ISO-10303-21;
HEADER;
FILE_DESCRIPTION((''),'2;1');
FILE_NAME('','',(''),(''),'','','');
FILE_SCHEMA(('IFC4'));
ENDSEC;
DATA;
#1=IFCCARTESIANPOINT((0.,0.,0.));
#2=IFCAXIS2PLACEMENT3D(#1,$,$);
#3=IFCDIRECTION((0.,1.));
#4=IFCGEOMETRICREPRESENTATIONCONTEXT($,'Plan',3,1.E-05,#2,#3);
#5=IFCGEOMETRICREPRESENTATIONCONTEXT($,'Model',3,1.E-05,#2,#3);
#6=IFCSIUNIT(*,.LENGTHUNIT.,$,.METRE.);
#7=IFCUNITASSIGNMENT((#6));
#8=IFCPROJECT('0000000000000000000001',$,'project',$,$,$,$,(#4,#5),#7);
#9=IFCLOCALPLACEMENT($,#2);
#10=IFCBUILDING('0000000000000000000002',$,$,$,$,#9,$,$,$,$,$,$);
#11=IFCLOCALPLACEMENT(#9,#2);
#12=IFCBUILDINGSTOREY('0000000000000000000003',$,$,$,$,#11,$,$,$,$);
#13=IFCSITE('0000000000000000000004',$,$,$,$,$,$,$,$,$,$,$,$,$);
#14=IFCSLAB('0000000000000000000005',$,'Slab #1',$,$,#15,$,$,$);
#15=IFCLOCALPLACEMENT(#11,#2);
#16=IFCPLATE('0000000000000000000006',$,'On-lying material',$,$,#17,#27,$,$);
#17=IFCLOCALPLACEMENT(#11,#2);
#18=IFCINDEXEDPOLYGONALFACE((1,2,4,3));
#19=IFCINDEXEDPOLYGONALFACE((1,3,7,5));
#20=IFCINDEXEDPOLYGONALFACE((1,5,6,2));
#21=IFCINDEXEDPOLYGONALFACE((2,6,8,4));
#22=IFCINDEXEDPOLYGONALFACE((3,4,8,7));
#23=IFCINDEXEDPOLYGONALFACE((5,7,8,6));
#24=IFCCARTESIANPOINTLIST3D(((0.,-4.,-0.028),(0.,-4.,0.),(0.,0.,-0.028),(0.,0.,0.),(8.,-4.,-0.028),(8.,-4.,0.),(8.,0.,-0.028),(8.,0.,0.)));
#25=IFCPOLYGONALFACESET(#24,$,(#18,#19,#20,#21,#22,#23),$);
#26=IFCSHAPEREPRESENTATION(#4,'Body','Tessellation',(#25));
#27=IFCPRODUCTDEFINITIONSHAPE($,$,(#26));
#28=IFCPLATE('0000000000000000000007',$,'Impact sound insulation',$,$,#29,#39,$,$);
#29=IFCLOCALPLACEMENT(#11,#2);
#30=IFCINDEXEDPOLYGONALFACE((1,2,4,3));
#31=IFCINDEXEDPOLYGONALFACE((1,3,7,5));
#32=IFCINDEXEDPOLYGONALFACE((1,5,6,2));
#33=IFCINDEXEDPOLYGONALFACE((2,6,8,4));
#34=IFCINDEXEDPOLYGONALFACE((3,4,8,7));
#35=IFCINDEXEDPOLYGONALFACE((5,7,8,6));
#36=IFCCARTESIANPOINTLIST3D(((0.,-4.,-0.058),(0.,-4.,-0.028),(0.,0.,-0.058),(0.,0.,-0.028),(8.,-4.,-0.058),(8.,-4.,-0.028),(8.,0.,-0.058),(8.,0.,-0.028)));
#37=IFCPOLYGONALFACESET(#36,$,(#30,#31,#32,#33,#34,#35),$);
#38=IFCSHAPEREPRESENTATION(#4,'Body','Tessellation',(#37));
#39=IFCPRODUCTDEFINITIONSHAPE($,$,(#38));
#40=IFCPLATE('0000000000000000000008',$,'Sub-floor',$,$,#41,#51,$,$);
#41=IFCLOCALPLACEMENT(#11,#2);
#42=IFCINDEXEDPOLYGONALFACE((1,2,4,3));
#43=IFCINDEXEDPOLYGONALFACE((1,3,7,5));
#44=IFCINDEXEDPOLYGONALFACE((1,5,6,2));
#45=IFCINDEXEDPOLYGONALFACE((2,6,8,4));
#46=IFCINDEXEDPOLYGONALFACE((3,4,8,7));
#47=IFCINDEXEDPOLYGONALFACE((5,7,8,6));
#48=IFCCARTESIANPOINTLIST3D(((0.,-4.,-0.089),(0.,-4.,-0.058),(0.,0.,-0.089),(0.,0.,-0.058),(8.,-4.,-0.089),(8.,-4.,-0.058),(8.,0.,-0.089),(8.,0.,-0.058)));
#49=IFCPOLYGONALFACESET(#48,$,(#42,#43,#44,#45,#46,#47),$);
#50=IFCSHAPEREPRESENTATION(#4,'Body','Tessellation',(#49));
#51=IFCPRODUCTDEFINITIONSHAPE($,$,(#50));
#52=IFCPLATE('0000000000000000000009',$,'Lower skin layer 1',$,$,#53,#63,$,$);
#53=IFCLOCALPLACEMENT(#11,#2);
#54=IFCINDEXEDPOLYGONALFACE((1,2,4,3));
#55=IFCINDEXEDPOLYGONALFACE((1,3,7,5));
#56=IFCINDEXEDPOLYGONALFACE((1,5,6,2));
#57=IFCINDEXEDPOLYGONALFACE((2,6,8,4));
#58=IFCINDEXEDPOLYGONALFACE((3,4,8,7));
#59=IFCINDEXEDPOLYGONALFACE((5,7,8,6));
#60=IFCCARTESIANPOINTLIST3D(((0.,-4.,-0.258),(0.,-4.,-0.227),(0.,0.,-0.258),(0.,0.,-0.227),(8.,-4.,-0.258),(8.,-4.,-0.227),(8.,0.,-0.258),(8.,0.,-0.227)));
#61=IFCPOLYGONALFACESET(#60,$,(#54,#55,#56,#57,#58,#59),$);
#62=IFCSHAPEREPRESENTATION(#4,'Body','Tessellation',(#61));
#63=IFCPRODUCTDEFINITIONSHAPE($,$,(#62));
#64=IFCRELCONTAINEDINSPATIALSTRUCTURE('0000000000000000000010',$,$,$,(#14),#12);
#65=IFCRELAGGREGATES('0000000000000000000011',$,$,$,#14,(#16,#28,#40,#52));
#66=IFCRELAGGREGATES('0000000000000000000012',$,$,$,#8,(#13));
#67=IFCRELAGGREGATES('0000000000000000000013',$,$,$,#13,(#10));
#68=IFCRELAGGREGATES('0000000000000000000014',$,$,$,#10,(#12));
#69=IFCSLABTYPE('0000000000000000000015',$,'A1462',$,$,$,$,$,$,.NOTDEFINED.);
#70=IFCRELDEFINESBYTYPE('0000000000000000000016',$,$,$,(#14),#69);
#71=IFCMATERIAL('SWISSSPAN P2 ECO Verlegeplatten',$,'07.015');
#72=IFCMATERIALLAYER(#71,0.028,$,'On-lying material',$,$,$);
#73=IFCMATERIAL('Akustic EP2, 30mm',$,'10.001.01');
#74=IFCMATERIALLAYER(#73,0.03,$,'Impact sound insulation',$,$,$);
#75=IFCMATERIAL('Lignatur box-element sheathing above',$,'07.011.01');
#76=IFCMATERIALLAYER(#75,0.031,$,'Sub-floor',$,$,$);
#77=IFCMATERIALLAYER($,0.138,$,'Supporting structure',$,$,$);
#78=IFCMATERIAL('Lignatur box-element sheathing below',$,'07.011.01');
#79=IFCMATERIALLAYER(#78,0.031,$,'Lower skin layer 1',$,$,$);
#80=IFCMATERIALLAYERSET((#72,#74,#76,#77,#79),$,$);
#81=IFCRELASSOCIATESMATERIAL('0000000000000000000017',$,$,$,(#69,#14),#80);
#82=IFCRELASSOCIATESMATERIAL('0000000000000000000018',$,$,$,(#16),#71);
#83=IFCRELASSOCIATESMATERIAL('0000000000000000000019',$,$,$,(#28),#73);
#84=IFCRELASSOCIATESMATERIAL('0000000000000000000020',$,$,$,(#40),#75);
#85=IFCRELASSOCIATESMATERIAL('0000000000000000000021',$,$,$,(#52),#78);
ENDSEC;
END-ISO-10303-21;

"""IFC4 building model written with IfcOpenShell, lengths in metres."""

from ifc_helpers import new_model, si_unit, direction, frame, frame_2d, origin, origin_with_axes, place, context, project, spatial, rectangle, extrude, material, layer, layer_set, type_object, element, aggregate, save


model = new_model("IFC4")

# Units and contexts
plan_context = context("Plan", 3, precision=1e-05, world=origin(), true_north=direction((0.0, 1.0)))
model_context = context("Model", 3, precision=1e-05, world=origin(), true_north=direction((0.0, 1.0)))
ifc_project = project(units=[si_unit("LENGTHUNIT", "METRE")], contexts=[plan_context, model_context])

# Site, building, storey
site = spatial("IfcSite", under=ifc_project)
building_placement = place(None, origin())
building = spatial("IfcBuilding", under=site, at=building_placement)
storey_placement = place(building_placement, origin())
storey = spatial("IfcBuildingStorey", under=building, at=storey_placement)

# Slab, plates
ifc_material_1 = material(Name="SWISSSPAN P2 ECO Verlegeplatten", Category="07.015")
ifc_layer_1 = layer(ifc_material_1, 0.028, Name="On-lying material")
ifc_material_2 = material(Name="Akustic EP2, 30mm", Category="10.001.01")
ifc_layer_2 = layer(ifc_material_2, 0.03, Name="Impact sound insulation")
ifc_material_3 = material(Name="Lignatur box-element sheathing above", Category="07.011.01")
ifc_layer_3 = layer(ifc_material_3, 0.031, Name="Sub-floor")
ifc_layer_4 = layer(None, 0.138, Name="Supporting structure")
ifc_material_4 = material(Name="Lignatur box-element sheathing below", Category="07.011.01")
ifc_layer_5 = layer(ifc_material_4, 0.031, Name="Lower skin layer 1")
ifc_layer_set = layer_set([ifc_layer_1, ifc_layer_2, ifc_layer_3, ifc_layer_4, ifc_layer_5])
slab_type = type_object("IfcSlabType", Name="A1462", PredefinedType="NOTDEFINED", material=ifc_layer_set)
slab_placement = place(None, frame((0.0, 0.0, 0.0), z_axis=(0.0, 0.0, -1.0), x_axis=(1.0, 0.0, 0.0)))
slab = element("IfcSlab", 1, at=slab_placement, inside=storey, type_object=slab_type, material=ifc_layer_set, Name="Slab #1")
plate_1_placement = place(slab_placement, origin())
plate_1 = element("IfcPlate", 2, at=plate_1_placement, material=ifc_material_1, Name="On-lying material", context=plan_context, shape_type="SweptSolid", body=[
    extrude(rectangle(XDim=8.0, YDim=4.0, at=frame_2d((4.0, 2.0), x_axis=(1.0, 0.0))), origin_with_axes(), (0.0, 0.0, 1.0), 0.028),
])
plate_2_placement = place(slab_placement, origin())
plate_2 = element("IfcPlate", 3, at=plate_2_placement, material=ifc_material_2, Name="Impact sound insulation", context=plan_context, shape_type="SweptSolid", body=[
    extrude(rectangle(XDim=8.0, YDim=4.0, at=frame_2d((4.0, 2.0), x_axis=(1.0, 0.0))), frame((0.0, 0.0, 0.028), z_axis=(0.0, 0.0, 1.0), x_axis=(1.0, 0.0, 0.0)), (0.0, 0.0, 1.0), 0.03),
])
plate_3_placement = place(slab_placement, origin())
plate_3 = element("IfcPlate", 4, at=plate_3_placement, material=ifc_material_3, Name="Sub-floor", context=plan_context, shape_type="SweptSolid", body=[
    extrude(rectangle(XDim=8.0, YDim=4.0, at=frame_2d((4.0, 2.0), x_axis=(1.0, 0.0))), frame((0.0, 0.0, 0.058), z_axis=(0.0, 0.0, 1.0), x_axis=(1.0, 0.0, 0.0)), (0.0, 0.0, 1.0), 0.031),
])
plate_4_placement = place(slab_placement, origin())
plate_4 = element("IfcPlate", 5, at=plate_4_placement, material=ifc_material_4, Name="Lower skin layer 1", context=plan_context, shape_type="SweptSolid", body=[
    extrude(rectangle(XDim=8.0, YDim=4.0, at=frame_2d((4.0, 2.0), x_axis=(1.0, 0.0))), frame((0.0, 0.0, 0.227), z_axis=(0.0, 0.0, 1.0), x_axis=(1.0, 0.0, 0.0)), (0.0, 0.0, 1.0), 0.031),
])
aggregate(slab, [plate_1, plate_2, plate_3, plate_4])

save(model, "model.ifc")
